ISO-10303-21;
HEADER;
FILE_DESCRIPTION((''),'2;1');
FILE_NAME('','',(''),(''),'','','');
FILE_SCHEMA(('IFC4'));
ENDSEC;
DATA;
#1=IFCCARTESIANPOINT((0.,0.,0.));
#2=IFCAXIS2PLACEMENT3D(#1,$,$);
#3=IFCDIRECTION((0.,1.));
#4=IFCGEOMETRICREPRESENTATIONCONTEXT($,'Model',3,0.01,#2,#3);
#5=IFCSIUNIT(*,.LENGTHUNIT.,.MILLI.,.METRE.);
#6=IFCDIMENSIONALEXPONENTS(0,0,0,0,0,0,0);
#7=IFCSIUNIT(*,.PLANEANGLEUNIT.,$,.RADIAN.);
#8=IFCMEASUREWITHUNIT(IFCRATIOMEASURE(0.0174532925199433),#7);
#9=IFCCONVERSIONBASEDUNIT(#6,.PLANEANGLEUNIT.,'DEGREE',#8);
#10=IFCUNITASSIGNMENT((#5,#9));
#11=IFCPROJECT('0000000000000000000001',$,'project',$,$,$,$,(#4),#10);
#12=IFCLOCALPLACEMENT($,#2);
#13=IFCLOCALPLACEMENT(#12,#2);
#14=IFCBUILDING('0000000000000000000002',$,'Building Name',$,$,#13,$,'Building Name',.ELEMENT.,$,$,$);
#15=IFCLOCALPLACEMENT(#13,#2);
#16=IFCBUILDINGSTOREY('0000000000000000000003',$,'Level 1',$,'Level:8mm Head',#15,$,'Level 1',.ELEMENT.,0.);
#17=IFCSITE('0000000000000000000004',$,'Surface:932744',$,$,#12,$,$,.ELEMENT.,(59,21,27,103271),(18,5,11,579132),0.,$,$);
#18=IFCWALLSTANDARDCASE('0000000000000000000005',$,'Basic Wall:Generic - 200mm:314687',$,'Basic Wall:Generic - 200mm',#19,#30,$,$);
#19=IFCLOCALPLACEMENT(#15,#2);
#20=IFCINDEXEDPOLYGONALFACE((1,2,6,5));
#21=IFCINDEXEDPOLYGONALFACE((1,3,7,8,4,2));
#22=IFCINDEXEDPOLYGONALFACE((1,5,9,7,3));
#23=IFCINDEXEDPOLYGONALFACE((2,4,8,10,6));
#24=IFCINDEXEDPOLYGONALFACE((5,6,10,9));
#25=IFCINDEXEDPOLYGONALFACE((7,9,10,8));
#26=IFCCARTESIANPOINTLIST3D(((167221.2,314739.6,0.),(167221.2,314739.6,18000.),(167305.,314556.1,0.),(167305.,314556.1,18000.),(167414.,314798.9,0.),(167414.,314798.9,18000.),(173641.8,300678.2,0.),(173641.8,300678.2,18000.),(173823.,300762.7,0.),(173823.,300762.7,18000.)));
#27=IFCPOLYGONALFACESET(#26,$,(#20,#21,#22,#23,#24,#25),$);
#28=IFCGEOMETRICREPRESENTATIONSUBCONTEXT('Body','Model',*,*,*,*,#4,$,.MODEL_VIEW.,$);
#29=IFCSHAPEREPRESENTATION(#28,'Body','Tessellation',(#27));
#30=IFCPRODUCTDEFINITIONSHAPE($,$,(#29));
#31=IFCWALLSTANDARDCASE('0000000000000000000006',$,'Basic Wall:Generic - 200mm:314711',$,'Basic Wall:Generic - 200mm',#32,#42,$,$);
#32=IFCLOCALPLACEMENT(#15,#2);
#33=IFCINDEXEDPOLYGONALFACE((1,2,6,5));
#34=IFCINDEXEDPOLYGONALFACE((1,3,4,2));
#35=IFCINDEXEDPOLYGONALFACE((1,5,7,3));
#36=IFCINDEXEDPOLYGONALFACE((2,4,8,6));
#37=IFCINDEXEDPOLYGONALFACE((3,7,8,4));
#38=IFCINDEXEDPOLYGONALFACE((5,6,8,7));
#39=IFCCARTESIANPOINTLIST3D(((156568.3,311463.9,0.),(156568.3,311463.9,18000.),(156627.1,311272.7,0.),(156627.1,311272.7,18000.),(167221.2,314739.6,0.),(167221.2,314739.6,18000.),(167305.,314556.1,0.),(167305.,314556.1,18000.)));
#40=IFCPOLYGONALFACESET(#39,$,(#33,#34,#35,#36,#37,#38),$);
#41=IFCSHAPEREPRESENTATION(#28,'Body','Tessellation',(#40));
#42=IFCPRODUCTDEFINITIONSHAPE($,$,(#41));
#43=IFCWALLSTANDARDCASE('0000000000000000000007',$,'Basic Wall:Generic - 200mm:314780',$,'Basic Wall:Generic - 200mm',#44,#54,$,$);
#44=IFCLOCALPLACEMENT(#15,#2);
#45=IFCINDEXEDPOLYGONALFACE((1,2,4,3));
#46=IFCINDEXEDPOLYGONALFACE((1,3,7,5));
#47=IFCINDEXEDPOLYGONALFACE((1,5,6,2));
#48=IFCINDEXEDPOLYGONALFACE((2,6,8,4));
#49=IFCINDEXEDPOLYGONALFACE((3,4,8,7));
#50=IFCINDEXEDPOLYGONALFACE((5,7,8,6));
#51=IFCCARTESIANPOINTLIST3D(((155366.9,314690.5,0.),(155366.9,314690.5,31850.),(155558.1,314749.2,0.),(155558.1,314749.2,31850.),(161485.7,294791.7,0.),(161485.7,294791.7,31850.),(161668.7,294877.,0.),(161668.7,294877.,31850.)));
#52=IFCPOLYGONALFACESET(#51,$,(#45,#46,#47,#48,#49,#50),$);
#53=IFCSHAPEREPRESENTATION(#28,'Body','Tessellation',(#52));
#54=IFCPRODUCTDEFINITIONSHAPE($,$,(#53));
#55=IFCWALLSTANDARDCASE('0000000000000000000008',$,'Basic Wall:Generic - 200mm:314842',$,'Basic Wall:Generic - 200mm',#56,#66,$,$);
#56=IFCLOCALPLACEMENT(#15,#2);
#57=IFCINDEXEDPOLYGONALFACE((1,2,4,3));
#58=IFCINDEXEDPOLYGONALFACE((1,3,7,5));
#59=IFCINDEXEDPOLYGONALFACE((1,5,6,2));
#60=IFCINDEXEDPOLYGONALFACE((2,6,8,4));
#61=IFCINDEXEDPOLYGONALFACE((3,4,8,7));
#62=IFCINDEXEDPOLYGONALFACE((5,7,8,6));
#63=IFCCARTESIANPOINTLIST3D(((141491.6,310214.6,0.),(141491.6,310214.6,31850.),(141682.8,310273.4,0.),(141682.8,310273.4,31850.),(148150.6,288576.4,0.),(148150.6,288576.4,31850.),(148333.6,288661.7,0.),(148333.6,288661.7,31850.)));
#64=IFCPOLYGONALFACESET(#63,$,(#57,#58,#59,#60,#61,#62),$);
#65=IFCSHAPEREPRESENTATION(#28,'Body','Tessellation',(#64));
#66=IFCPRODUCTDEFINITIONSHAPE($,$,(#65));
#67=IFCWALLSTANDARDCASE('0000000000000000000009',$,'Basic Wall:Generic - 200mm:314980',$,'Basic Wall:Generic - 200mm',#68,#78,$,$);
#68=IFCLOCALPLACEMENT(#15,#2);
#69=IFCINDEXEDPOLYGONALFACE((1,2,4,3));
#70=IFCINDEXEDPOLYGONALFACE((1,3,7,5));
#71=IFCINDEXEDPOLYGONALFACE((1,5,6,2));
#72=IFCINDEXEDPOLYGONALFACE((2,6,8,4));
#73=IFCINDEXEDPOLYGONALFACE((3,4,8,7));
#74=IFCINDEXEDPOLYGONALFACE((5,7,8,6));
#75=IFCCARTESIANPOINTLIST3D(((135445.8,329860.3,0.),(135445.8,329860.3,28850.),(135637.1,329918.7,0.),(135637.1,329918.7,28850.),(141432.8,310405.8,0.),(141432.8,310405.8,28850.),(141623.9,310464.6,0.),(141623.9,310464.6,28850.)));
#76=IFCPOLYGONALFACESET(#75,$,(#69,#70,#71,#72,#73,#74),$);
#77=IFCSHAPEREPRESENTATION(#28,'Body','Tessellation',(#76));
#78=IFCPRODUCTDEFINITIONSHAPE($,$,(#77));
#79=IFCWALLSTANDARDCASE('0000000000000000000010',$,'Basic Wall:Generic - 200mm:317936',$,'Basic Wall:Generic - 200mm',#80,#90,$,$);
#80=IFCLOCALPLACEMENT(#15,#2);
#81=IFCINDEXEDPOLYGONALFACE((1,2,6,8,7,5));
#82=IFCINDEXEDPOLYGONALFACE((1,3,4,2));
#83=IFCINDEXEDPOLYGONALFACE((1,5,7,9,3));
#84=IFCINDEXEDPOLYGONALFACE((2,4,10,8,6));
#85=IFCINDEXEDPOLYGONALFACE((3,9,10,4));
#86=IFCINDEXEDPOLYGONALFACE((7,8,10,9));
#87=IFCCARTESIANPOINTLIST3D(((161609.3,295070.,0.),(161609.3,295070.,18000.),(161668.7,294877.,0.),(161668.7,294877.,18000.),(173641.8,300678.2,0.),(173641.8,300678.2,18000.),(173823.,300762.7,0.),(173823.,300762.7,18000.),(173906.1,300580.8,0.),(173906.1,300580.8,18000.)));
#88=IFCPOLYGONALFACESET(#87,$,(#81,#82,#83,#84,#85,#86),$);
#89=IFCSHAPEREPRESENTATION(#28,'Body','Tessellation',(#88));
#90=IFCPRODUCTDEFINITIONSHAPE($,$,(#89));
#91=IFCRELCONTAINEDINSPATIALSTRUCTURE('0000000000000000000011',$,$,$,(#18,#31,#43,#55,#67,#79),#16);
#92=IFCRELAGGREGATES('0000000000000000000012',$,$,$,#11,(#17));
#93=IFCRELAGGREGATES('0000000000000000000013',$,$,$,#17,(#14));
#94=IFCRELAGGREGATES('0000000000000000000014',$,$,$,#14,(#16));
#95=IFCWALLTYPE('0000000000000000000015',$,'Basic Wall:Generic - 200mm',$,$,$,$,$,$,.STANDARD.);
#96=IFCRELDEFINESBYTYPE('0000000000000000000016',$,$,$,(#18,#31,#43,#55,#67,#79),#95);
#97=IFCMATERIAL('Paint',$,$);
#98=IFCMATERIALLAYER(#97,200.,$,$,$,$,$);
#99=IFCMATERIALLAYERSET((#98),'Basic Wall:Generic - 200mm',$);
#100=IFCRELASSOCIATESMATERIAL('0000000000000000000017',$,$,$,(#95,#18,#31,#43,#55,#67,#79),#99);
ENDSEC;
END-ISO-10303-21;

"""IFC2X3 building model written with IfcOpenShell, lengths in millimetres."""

from ifc_helpers import new_model, entity, si_unit, converted_unit, direction, frame, origin, place, context, subcontext, project, spatial, polyline, outline, extrude, clip, bounded_halfspace, material, layer, layer_set, layer_usage, type_object, element, save


model = new_model("IFC2X3")

# Units and contexts
model_context = context("Model", 3, precision=0.01, world=origin(), true_north=direction((0.0, 1.0)))
body_context = subcontext(model_context, "Body", "Model", "MODEL_VIEW")
ifc_project = project(units=[si_unit("LENGTHUNIT", "METRE", prefix="MILLI"), converted_unit("PLANEANGLEUNIT", "DEGREE", entity("IfcRatioMeasure", 0.0174532925199433), si_unit("PLANEANGLEUNIT", "RADIAN"), dimensions=[0, 0, 0, 0, 0, 0, 0])], contexts=[model_context])

# Site, building, storey
site_placement = place(None, origin())
site = spatial("IfcSite", under=ifc_project, at=site_placement, Name="Surface:932744", CompositionType="ELEMENT", RefLatitude=(59, 21, 27, 103271), RefLongitude=(18, 5, 11, 579132), RefElevation=0.0)
building_placement = place(site_placement, origin())
building = spatial("IfcBuilding", under=site, at=building_placement, Name="Building Name", LongName="Building Name", CompositionType="ELEMENT")
storey_placement = place(building_placement, origin())
storey = spatial("IfcBuildingStorey", under=building, at=storey_placement, Name="Level 1", ObjectType="Level:8mm Head", LongName="Level 1", CompositionType="ELEMENT", Elevation=0.0)

# Walls
ifc_material_1 = material(Name="Paint")
ifc_layer_1 = layer(ifc_material_1, 200.0)
ifc_layer_set_1 = layer_set([ifc_layer_1], Name="Basic Wall:Generic - 200mm")
wall_type = type_object("IfcWallType", Name="Basic Wall:Generic - 200mm", PredefinedType="STANDARD", material=ifc_layer_set_1)
ifc_layer_usage_1 = layer_usage(ifc_layer_set_1, "AXIS2", "NEGATIVE", 100.0)
wall_1_placement = place(storey_placement, frame((173732.7, 300719.7, 0.0), z_axis=(0.0, 0.0, 1.0), x_axis=(-0.415358, 0.909658, 0.0)))
element("IfcWallStandardCase", 1, at=wall_1_placement, inside=storey, type_object=wall_type, material=ifc_layer_usage_1, Name="Basic Wall:Generic - 200mm:314687", ObjectType="Basic Wall:Generic - 200mm", context=body_context, shape_type="SweptSolid", body=[
    extrude(outline(polyline([(15431.7, -100.0), (15457.9, 100.0), (15256.2, 100.0), (0.0, 100.0), (1.6, -100.0), (15431.7, -100.0)])), origin(), (0.0, 0.0, 1.0), 18000.0),
])
ifc_layer_usage_2 = layer_usage(ifc_layer_set_1, "AXIS2", "NEGATIVE", 100.0)
wall_2_placement = place(storey_placement, frame((167275.6, 314651.7, 0.0), z_axis=(0.0, 0.0, 1.0), x_axis=(-0.955832, -0.293913, 0.0)))
element("IfcWallStandardCase", 2, at=wall_2_placement, inside=storey, type_object=wall_type, material=ifc_layer_usage_2, Name="Basic Wall:Generic - 200mm:314711", ObjectType="Basic Wall:Generic - 200mm", context=body_context, shape_type="SweptSolid", body=[
    extrude(outline(polyline([(11171.3, -100.0), (11171.3, 100.0), (0.0, 100.0), (26.2, -100.0), (11171.3, -100.0)])), origin(), (0.0, 0.0, 1.0), 18000.0),
])
ifc_layer_usage_3 = layer_usage(ifc_layer_set_1, "AXIS2", "NEGATIVE", 100.0)
wall_3_placement = place(storey_placement, frame((161581.2, 294821.1, 0.0), z_axis=(0.0, 0.0, 1.0), x_axis=(-0.293913, 0.955832, 0.0)))
element("IfcWallStandardCase", 3, at=wall_3_placement, inside=storey, type_object=wall_type, material=ifc_layer_usage_3, Name="Basic Wall:Generic - 200mm:314780", ObjectType="Basic Wall:Generic - 200mm", context=body_context, shape_type="Clipping", body=[
    clip(extrude(outline(polyline([(20818.2, -100.0), (20818.2, 100.0), (20618.2, 100.0), (201.9, 100.0), (0.0, 100.0), (27.7, -100.0), (229.7, -100.0), (17181.1, -100.0), (17381.1, -100.0), (20818.2, -100.0)])), origin(), (0.0, 0.0, 1.0), 31850.0), bounded_halfspace(frame((27.7, -100.0, 31850.0), z_axis=(0.0, 0.0, -1.0), x_axis=(-1.0, 0.0, 0.0)), True, frame((27.7, -100.0, 31850.0), z_axis=(0.0, 0.0, -1.0), x_axis=(-1.0, 0.0, 0.0)), polyline([(0.0, 0.0), (27.7, 200.0), (-174.2, 200.0), (-20590.5, 200.0), (-20790.5, 200.0), (-20790.5, 0.0), (0.0, 0.0)]))),
])

# Wall
ifc_layer_usage_4 = layer_usage(ifc_layer_set_1, "AXIS2", "NEGATIVE", 100.0)
wall_4_placement = place(storey_placement, frame((141587.2, 310244.0, 0.0), z_axis=(0.0, 0.0, 1.0), x_axis=(0.294128, -0.955766, 0.0)))
element("IfcWallStandardCase", 4, at=wall_4_placement, inside=storey, type_object=wall_type, material=ifc_layer_usage_4, Name="Basic Wall:Generic - 200mm:314842", ObjectType="Basic Wall:Generic - 200mm", context=body_context, shape_type="Clipping", body=[
    clip(extrude(outline(polyline([(22639.7, -100.0), (22612.0, 100.0), (22410.1, 100.0), (0.0, 100.0), (0.0, -100.0), (22639.7, -100.0)])), origin(), (0.0, 0.0, 1.0), 31850.0), bounded_halfspace(frame((0.0, -100.0, 31850.0), z_axis=(0.0, 0.0, -1.0), x_axis=(1.0, -0.000225, 0.0)), True, frame((0.0, -100.0, 31850.0), z_axis=(0.0, 0.0, -1.0), x_axis=(1.0, -0.000225, 0.0)), polyline([(0.0, 0.0), (0.0, -200.0), (22410.1, -205.0), (22612.0, -205.1), (22639.7, -5.1), (0.0, 0.0)]))),
])

# Walls
ifc_layer_usage_5 = layer_usage(ifc_layer_set_1, "AXIS2", "NEGATIVE", 100.0)
wall_5_placement = place(storey_placement, frame((135541.4, 329889.7, 0.0), z_axis=(0.0, 0.0, 1.0), x_axis=(0.294128, -0.955766, 0.0)))
element("IfcWallStandardCase", 5, at=wall_5_placement, inside=storey, type_object=wall_type, material=ifc_layer_usage_5, Name="Basic Wall:Generic - 200mm:314980", ObjectType="Basic Wall:Generic - 200mm", context=body_context, shape_type="Clipping", body=[
    clip(extrude(outline(polyline([(20354.9, -100.0), (20355.0, 100.0), (0.4, 100.0), (0.0, -100.0), (20354.9, -100.0)])), origin(), (0.0, 0.0, 1.0), 28850.0), bounded_halfspace(frame((0.0, -100.0, 28850.0), z_axis=(0.0, 0.0, -1.0), x_axis=(-0.000225, -1.0, 0.0)), True, frame((0.0, -100.0, 28850.0), z_axis=(0.0, 0.0, -1.0), x_axis=(-0.000225, -1.0, 0.0)), polyline([(0.0, 0.0), (-200.0, -0.4), (-204.6, -20354.9), (-4.6, -20354.9), (0.0, 0.0)]))),
])
ifc_layer_usage_6 = layer_usage(ifc_layer_set_1, "AXIS2", "NEGATIVE", 100.0)
wall_6_placement = place(storey_placement, frame((173865.3, 300672.1, 0.0), z_axis=(0.0, 0.0, 1.0), x_axis=(-0.906384, -0.422456, 0.0)))
element("IfcWallStandardCase", 6, at=wall_6_placement, inside=storey, type_object=wall_type, material=ifc_layer_usage_6, Name="Basic Wall:Generic - 200mm:317936", ObjectType="Basic Wall:Generic - 200mm", context=body_context, shape_type="SweptSolid", body=[
    extrude(outline(polyline([(13475.2, -100.0), (13503.0, 100.0), (1.6, 100.0), (0.0, -100.0), (200.0, -100.0), (13475.2, -100.0)])), origin(), (0.0, 0.0, 1.0), 18000.0),
])

save(model, "model.ifc")
